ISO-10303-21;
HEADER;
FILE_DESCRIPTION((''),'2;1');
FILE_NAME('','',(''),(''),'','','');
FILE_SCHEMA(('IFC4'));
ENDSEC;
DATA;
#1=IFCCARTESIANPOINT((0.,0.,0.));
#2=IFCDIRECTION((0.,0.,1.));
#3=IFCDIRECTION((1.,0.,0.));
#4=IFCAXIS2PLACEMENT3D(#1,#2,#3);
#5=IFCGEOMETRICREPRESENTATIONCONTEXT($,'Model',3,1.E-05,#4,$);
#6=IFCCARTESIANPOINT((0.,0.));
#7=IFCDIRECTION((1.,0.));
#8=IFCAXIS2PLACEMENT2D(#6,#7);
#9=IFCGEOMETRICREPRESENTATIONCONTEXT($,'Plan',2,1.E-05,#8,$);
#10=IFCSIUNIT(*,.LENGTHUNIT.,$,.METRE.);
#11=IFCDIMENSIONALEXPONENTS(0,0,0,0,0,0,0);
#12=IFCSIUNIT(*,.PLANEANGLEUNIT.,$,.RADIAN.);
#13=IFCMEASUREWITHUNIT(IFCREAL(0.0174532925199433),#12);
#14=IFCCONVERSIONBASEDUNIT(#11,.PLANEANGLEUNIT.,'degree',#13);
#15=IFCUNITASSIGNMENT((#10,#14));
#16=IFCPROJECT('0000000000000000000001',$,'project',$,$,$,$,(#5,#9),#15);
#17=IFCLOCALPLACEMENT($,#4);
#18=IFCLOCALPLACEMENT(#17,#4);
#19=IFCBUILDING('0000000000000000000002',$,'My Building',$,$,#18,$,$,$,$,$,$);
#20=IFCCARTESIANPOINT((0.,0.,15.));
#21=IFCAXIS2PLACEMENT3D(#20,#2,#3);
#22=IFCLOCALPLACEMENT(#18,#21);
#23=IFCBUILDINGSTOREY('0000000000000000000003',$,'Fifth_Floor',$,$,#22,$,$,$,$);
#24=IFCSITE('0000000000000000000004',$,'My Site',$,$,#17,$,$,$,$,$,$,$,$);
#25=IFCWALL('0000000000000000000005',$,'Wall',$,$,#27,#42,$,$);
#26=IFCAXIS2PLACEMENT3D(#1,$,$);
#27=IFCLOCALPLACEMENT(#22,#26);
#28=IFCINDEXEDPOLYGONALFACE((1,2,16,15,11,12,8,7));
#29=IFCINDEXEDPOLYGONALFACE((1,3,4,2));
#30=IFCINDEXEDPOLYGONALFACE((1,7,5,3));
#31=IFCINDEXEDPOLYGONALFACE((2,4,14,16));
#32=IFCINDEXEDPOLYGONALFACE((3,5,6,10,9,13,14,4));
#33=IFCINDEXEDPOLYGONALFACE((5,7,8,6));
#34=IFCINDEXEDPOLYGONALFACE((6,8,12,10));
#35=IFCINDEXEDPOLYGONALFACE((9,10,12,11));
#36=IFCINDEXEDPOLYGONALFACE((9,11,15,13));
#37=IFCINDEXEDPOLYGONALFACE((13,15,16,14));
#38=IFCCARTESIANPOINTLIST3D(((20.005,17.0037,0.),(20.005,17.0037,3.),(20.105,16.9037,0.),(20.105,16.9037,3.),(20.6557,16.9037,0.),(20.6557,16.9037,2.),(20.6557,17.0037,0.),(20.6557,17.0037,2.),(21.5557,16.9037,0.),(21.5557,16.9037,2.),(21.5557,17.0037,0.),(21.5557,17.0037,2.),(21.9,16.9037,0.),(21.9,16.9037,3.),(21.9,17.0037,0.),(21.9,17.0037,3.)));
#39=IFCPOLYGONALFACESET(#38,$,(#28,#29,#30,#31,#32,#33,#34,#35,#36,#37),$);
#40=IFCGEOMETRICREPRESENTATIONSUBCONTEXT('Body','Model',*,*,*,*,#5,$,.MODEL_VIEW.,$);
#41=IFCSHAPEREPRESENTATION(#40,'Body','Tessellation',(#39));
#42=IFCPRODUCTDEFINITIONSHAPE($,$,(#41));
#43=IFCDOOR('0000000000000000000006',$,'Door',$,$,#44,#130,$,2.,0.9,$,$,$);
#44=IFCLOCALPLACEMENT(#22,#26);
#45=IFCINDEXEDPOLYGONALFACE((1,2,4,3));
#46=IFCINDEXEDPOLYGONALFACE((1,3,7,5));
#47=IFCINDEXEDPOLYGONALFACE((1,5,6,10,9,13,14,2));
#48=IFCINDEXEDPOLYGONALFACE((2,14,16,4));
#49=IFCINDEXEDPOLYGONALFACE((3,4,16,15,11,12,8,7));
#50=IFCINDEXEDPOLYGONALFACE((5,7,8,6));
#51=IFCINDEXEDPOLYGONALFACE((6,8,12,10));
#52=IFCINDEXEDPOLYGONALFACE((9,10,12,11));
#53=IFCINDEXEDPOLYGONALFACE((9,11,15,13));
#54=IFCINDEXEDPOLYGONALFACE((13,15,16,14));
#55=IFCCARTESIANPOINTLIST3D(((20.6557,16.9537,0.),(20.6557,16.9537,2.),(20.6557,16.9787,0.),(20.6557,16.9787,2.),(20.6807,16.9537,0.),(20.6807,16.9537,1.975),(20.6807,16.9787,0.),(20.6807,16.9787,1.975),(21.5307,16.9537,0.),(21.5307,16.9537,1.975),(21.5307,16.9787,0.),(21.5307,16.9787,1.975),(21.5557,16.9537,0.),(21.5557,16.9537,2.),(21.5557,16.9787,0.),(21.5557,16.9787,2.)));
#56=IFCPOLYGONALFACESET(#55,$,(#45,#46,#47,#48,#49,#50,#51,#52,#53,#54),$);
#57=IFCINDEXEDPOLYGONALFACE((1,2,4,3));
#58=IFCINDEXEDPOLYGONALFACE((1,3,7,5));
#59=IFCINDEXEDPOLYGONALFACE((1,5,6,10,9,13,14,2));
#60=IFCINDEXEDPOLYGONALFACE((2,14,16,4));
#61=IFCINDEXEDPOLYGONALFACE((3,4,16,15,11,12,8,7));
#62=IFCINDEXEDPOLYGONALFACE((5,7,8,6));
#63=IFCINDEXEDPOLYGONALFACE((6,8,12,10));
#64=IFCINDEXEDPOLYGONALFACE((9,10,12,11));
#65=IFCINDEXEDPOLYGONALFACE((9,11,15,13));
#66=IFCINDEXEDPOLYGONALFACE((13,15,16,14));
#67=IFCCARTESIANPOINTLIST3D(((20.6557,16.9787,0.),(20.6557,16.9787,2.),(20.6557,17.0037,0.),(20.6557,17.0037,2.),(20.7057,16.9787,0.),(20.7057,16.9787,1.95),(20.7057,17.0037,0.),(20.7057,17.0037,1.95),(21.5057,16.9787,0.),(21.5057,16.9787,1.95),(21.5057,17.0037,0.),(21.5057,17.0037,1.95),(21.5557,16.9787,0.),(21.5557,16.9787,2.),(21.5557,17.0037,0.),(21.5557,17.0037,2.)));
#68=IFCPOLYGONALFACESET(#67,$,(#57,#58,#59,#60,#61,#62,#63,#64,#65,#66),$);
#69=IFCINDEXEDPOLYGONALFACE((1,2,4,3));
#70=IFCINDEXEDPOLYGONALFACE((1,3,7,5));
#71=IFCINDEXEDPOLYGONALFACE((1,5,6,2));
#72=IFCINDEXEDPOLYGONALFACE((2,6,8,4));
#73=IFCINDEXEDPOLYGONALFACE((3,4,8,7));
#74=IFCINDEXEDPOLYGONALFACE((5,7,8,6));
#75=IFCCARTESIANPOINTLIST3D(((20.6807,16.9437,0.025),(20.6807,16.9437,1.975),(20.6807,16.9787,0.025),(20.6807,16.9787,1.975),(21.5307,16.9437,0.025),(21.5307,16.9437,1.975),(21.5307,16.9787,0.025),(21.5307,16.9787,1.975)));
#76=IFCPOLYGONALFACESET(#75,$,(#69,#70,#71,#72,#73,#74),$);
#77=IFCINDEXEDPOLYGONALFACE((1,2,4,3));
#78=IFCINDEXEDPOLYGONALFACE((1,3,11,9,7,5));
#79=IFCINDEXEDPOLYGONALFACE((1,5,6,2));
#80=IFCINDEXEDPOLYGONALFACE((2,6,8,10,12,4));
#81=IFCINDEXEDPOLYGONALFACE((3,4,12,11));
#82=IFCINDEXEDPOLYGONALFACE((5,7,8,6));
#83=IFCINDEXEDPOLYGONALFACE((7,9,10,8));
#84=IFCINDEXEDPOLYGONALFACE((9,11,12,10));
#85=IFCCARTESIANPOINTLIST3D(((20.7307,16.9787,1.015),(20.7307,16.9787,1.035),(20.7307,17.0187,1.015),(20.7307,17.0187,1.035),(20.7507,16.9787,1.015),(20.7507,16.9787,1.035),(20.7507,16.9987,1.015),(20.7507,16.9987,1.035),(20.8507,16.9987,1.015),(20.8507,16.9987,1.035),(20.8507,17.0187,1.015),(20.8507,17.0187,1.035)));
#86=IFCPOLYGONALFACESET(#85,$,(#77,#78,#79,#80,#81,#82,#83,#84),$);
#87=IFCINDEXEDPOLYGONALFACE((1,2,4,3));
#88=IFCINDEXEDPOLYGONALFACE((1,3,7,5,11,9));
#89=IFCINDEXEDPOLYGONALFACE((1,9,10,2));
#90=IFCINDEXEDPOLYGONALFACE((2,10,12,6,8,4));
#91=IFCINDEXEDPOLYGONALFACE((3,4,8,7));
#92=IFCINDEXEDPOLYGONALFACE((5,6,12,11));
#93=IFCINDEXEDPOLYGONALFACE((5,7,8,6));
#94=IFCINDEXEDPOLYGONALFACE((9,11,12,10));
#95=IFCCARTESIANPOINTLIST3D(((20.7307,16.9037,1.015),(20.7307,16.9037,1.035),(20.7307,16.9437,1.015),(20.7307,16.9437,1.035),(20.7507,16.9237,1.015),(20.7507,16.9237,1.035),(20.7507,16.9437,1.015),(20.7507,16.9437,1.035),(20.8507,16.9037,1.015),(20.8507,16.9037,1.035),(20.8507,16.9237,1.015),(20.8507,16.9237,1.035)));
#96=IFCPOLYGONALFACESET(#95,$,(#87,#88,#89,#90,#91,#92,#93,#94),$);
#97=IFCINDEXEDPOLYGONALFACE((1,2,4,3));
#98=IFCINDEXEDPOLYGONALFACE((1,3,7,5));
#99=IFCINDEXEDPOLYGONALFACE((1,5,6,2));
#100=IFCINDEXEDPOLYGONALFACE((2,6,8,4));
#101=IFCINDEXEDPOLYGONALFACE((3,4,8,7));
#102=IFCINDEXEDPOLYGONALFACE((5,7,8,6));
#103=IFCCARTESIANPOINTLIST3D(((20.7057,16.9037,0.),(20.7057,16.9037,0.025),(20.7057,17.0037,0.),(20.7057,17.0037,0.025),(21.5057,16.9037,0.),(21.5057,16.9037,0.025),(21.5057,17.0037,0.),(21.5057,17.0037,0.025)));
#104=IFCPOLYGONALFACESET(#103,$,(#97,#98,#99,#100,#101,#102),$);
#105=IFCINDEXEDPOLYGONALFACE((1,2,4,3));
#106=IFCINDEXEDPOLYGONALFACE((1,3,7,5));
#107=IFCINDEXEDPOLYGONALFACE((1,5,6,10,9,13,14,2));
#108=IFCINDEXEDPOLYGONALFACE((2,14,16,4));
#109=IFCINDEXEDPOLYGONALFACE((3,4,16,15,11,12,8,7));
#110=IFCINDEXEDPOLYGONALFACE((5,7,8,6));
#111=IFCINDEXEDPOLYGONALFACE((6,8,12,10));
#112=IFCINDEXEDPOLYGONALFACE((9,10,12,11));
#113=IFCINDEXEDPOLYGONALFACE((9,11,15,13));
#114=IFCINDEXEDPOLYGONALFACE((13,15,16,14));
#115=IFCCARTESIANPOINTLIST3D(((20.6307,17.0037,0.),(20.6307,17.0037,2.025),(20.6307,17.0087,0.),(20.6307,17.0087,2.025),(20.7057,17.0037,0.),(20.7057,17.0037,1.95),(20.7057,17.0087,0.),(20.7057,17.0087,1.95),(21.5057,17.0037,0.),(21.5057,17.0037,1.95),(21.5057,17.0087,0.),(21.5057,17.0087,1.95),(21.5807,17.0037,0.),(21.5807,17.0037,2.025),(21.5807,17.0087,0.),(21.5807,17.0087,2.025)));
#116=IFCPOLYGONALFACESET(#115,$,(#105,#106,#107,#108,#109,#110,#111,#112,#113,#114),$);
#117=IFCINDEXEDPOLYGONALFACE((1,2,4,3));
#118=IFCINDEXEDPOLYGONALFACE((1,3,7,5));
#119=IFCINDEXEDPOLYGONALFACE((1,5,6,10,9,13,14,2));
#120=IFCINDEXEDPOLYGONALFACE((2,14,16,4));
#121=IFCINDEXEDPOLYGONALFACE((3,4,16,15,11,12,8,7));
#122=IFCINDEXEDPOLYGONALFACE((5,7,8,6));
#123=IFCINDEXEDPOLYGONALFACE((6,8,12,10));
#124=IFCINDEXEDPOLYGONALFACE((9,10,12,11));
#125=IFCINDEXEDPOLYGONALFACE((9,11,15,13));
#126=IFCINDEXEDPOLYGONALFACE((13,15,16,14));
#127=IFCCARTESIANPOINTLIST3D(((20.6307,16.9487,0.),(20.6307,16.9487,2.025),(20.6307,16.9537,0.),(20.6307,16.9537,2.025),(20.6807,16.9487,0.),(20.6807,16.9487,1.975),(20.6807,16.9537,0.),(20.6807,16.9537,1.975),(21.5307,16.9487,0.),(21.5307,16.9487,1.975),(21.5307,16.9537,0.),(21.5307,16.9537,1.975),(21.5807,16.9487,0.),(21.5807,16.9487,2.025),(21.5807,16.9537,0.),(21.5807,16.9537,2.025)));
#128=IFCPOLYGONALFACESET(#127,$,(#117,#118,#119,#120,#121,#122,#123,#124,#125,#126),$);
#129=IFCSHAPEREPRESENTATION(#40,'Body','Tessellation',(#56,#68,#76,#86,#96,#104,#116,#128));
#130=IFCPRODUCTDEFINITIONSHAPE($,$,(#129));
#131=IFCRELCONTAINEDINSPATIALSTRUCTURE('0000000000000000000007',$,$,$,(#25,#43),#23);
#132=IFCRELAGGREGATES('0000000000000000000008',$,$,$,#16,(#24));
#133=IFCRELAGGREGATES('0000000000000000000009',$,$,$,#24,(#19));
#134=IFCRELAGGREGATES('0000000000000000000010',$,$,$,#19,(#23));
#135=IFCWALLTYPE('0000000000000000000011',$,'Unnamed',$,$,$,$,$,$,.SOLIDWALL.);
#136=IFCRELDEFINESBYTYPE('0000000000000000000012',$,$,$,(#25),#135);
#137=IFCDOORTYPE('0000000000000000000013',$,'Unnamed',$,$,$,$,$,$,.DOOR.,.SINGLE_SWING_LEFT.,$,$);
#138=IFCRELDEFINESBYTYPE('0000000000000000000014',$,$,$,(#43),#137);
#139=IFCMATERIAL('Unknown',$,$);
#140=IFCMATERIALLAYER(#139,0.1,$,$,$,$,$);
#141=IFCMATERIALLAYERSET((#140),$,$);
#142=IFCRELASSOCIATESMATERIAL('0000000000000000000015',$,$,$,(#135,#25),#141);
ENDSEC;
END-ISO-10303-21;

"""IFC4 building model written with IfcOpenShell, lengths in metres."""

from ifc_helpers import new_model, entity, si_unit, converted_unit, frame, origin_with_axes, origin_2d_with_axis, place, context, subcontext, project, spatial, line, indexed_curve, outline, extrude, shape, source, transform, mapped, material, layer, layer_set, layer_usage, type_object, type_shapes, element, fill, save


model = new_model("IFC4")

# Units and contexts
model_context = context("Model", 3, precision=1e-05, world=origin_with_axes())
plan_context = context("Plan", 2, precision=1e-05, world=origin_2d_with_axis())
body_context_1 = subcontext(model_context, "Body", "Model", "MODEL_VIEW")
body_context_2 = subcontext(plan_context, "Body", "Plan", "PLAN_VIEW")
ifc_project = project(units=[si_unit("LENGTHUNIT", "METRE"), converted_unit("PLANEANGLEUNIT", "degree", entity("IfcReal", 0.0174532925199433), si_unit("PLANEANGLEUNIT", "RADIAN"), dimensions=[0, 0, 0, 0, 0, 0, 0])], contexts=[model_context, plan_context])

# Site, building, storey
site_placement = place(None, origin_with_axes())
site = spatial("IfcSite", under=ifc_project, at=site_placement, Name="My Site")
building_placement = place(site_placement, origin_with_axes())
building = spatial("IfcBuilding", under=site, at=building_placement, Name="My Building")
storey_placement = place(building_placement, frame((0.0, 0.0, 15.0), z_axis=(0.0, 0.0, 1.0), x_axis=(1.0, 0.0, 0.0)))
storey = spatial("IfcBuildingStorey", under=building, at=storey_placement, Name="Fifth_Floor")

# Shared definitions
ifc_material = material(Name="Unknown")
ifc_layer = layer(ifc_material, 0.1)
ifc_layer_set = layer_set([ifc_layer])
wall_type = type_object("IfcWallType", Name="Unnamed", PredefinedType="SOLIDWALL", material=ifc_layer_set)

# Wall, opening, door
ifc_layer_usage_1 = layer_usage(ifc_layer_set, "AXIS2", "POSITIVE", 0.0)
wall_1_placement = place(storey_placement, frame((21.9, 17.0037, 0.0), z_axis=(0.0, 0.0, 1.0), x_axis=(-1.0, 0.0, 0.0)))
wall_1 = element("IfcWall", 1, at=wall_1_placement, inside=storey, type_object=wall_type, material=ifc_layer_usage_1, Name="Wall", context=body_context_1, shape_type="SweptSolid", body=[
    extrude(outline(indexed_curve([(0.0, 0.0), (0.0, 0.1), (1.795, 0.1), (1.895, 0.0)], segments=[line(1, 2, 3, 4, 1)])), origin_with_axes(), (0.0, 0.0, 1.0), 3.0),
])
shared_shape_1 = source(origin_with_axes(), body_context_1, "Body", "SweptSolid", [
    extrude(outline(indexed_curve([(0.0, 0.0), (0.9, 0.0), (0.9, 2.0), (0.0, 2.0)], segments=[line(1, 2, 3, 4, 1)])), frame((0.0, -0.6, 0.0), z_axis=(0.0, -1.0, 0.0), x_axis=(1.0, 0.0, 0.0)), (0.0, 0.0, -1.0), 1.2),
])
opening_1_placement = place(wall_1_placement, frame((0.3443, 0.0, 0.0), z_axis=(0.0, 0.0, 1.0), x_axis=(1.0, 0.0, 0.0)))
opening_1 = element("IfcOpeningElement", 2, at=opening_1_placement, cuts=wall_1, PredefinedType="OPENING", context=body_context_1, shape_type="MappedRepresentation", body=[
    mapped(shared_shape_1, transform((0.0, 0.0, 0.0), x_axis=(1.0, 0.0, 0.0), y_axis=(0.0, 1.0, 0.0), z_axis=(0.0, 0.0, 1.0), scale=1.0)),
])
door_type = type_object("IfcDoorType", Name="Unnamed", OperationType="SINGLE_SWING_LEFT", PredefinedType="DOOR")
shared_shape_2 = source(origin_with_axes(), body_context_1, "Body", "SweptSolid", [
    extrude(outline(indexed_curve([(0.0, 0.0), (0.0, 2.0), (0.9, 2.0), (0.9, 0.0), (0.875, 0.0), (0.875, 1.975), (0.025, 1.975), (0.025, 0.0)], segments=[line(1, 2, 3, 4, 5, 6, 7, 8, 1)])), frame((0.0, 0.025, 0.0), z_axis=(0.0, -1.0, 0.0), x_axis=(1.0, 0.0, 0.0)), (0.0, 0.0, -1.0), 0.025),
    extrude(outline(indexed_curve([(0.0, 0.0), (0.0, 2.0), (0.9, 2.0), (0.9, 0.0), (0.85, 0.0), (0.85, 1.95), (0.05, 1.95), (0.05, 0.0)], segments=[line(1, 2, 3, 4, 5, 6, 7, 8, 1)])), frame((0.0, 0.0, 0.0), z_axis=(0.0, -1.0, 0.0), x_axis=(1.0, 0.0, 0.0)), (0.0, 0.0, -1.0), 0.025),
    extrude(outline(indexed_curve([(0.0, 0.0), (0.85, 0.0), (0.85, 0.035), (0.0, 0.035)], segments=[line(1, 2, 3, 4, 1)])), frame((0.025, 0.025, 0.025), z_axis=(0.0, 0.0, 1.0), x_axis=(1.0, 0.0, 0.0)), (0.0, 0.0, 1.0), 1.95),
    extrude(outline(indexed_curve([(0.0, 0.0), (0.0, -0.04), (-0.12, -0.04), (-0.12, -0.02), (-0.02, -0.02), (-0.02, 0.0)], segments=[line(1, 2, 3, 4, 5, 6, 1)])), frame((0.825, 0.025, 1.015), z_axis=(0.0, 0.0, 1.0), x_axis=(1.0, 0.0, 0.0)), (0.0, 0.0, 1.0), 0.02),
    extrude(outline(indexed_curve([(0.0, 0.0), (0.0, 0.04), (-0.12, 0.04), (-0.12, 0.02), (-0.02, 0.02), (-0.02, 0.0)], segments=[line(1, 2, 3, 4, 5, 6, 1)])), frame((0.825, 0.06, 1.015), z_axis=(0.0, 0.0, 1.0), x_axis=(1.0, 0.0, 0.0)), (0.0, 0.0, 1.0), 0.02),
    extrude(outline(indexed_curve([(0.0, 0.0), (0.8, 0.0), (0.8, 0.1), (0.0, 0.1)], segments=[line(1, 2, 3, 4, 1)])), frame((0.05, 0.0, 0.0), z_axis=(0.0, 0.0, 1.0), x_axis=(1.0, 0.0, 0.0)), (0.0, 0.0, 1.0), 0.025),
    extrude(outline(indexed_curve([(0.0, 0.0), (0.0, 2.025), (0.95, 2.025), (0.95, 0.0), (0.875, 0.0), (0.875, 1.95), (0.075, 1.95), (0.075, 0.0)], segments=[line(1, 2, 3, 4, 5, 6, 7, 8, 1)])), frame((-0.025, -0.005, 0.0), z_axis=(0.0, -1.0, 0.0), x_axis=(1.0, 0.0, 0.0)), (0.0, 0.0, -1.0), 0.005),
    extrude(outline(indexed_curve([(0.0, 0.0), (0.0, 2.025), (0.95, 2.025), (0.95, 0.0), (0.9, 0.0), (0.9, 1.975), (0.05, 1.975), (0.05, 0.0)], segments=[line(1, 2, 3, 4, 5, 6, 7, 8, 1)])), frame((-0.025, 0.05, 0.0), z_axis=(0.0, -1.0, 0.0), x_axis=(1.0, 0.0, 0.0)), (0.0, 0.0, -1.0), 0.005),
])
shared_shape_3 = source(origin_with_axes(), body_context_2, "Body", "Curve2D", [
    entity("IfcIndexedPolyCurve", entity("IfcCartesianPointList2D", [[0.0, 0.0], [0.0, 0.05], [0.025, 0.05], [0.025, 0.025], [0.05, 0.025], [0.05, 0.0]]), [entity("IfcLineIndex", [1, 2, 3, 4, 5, 6, 1])]),
    entity("IfcIndexedPolyCurve", entity("IfcCartesianPointList2D", [[0.9, 0.0], [0.9, 0.05], [0.875, 0.05], [0.875, 0.025], [0.85, 0.025], [0.85, 0.0]]), [entity("IfcLineIndex", [1, 2, 3, 4, 5, 6, 1])]),
    entity("IfcTrimmedCurve", entity("IfcEllipse", entity("IfcAxis2Placement2D", entity("IfcCartesianPoint", [0.06, 0.05]), entity("IfcDirection", [1.0, 0.0])), 0.815, 0.85), [entity("IfcCartesianPoint", [0.875, 0.05])], [entity("IfcCartesianPoint", [0.06, 0.9])], True, "CARTESIAN"),
    entity("IfcIndexedPolyCurve", entity("IfcCartesianPointList2D", [[0.025, 0.05], [0.06, 0.05], [0.06, 0.9], [0.025, 0.9]]), [entity("IfcLineIndex", [1, 2, 3, 4, 1])]),
])
type_shapes(door_type, [shared_shape_2, shared_shape_3])
door_1_placement = place(opening_1_placement, origin_with_axes())
door_1 = element("IfcDoor", 3, at=door_1_placement, inside=storey, type_object=door_type, Name="Door", OverallHeight=2.0, OverallWidth=0.9, shapes=[
    shape(body_context_1, "Body", "MappedRepresentation", [mapped(shared_shape_2, transform((0.0, 0.0, 0.0), x_axis=(1.0, 0.0, 0.0), y_axis=(0.0, 1.0, 0.0), z_axis=(0.0, 0.0, 1.0), scale=1.0))]),
    shape(body_context_2, "Body", "MappedRepresentation", [mapped(shared_shape_3, transform((0.0, 0.0, 0.0), x_axis=(1.0, 0.0, 0.0), y_axis=(0.0, 1.0, 0.0), z_axis=(0.0, 0.0, 1.0), scale=1.0))]),
])
fill(opening_1, door_1)

save(model, "model.ifc")
